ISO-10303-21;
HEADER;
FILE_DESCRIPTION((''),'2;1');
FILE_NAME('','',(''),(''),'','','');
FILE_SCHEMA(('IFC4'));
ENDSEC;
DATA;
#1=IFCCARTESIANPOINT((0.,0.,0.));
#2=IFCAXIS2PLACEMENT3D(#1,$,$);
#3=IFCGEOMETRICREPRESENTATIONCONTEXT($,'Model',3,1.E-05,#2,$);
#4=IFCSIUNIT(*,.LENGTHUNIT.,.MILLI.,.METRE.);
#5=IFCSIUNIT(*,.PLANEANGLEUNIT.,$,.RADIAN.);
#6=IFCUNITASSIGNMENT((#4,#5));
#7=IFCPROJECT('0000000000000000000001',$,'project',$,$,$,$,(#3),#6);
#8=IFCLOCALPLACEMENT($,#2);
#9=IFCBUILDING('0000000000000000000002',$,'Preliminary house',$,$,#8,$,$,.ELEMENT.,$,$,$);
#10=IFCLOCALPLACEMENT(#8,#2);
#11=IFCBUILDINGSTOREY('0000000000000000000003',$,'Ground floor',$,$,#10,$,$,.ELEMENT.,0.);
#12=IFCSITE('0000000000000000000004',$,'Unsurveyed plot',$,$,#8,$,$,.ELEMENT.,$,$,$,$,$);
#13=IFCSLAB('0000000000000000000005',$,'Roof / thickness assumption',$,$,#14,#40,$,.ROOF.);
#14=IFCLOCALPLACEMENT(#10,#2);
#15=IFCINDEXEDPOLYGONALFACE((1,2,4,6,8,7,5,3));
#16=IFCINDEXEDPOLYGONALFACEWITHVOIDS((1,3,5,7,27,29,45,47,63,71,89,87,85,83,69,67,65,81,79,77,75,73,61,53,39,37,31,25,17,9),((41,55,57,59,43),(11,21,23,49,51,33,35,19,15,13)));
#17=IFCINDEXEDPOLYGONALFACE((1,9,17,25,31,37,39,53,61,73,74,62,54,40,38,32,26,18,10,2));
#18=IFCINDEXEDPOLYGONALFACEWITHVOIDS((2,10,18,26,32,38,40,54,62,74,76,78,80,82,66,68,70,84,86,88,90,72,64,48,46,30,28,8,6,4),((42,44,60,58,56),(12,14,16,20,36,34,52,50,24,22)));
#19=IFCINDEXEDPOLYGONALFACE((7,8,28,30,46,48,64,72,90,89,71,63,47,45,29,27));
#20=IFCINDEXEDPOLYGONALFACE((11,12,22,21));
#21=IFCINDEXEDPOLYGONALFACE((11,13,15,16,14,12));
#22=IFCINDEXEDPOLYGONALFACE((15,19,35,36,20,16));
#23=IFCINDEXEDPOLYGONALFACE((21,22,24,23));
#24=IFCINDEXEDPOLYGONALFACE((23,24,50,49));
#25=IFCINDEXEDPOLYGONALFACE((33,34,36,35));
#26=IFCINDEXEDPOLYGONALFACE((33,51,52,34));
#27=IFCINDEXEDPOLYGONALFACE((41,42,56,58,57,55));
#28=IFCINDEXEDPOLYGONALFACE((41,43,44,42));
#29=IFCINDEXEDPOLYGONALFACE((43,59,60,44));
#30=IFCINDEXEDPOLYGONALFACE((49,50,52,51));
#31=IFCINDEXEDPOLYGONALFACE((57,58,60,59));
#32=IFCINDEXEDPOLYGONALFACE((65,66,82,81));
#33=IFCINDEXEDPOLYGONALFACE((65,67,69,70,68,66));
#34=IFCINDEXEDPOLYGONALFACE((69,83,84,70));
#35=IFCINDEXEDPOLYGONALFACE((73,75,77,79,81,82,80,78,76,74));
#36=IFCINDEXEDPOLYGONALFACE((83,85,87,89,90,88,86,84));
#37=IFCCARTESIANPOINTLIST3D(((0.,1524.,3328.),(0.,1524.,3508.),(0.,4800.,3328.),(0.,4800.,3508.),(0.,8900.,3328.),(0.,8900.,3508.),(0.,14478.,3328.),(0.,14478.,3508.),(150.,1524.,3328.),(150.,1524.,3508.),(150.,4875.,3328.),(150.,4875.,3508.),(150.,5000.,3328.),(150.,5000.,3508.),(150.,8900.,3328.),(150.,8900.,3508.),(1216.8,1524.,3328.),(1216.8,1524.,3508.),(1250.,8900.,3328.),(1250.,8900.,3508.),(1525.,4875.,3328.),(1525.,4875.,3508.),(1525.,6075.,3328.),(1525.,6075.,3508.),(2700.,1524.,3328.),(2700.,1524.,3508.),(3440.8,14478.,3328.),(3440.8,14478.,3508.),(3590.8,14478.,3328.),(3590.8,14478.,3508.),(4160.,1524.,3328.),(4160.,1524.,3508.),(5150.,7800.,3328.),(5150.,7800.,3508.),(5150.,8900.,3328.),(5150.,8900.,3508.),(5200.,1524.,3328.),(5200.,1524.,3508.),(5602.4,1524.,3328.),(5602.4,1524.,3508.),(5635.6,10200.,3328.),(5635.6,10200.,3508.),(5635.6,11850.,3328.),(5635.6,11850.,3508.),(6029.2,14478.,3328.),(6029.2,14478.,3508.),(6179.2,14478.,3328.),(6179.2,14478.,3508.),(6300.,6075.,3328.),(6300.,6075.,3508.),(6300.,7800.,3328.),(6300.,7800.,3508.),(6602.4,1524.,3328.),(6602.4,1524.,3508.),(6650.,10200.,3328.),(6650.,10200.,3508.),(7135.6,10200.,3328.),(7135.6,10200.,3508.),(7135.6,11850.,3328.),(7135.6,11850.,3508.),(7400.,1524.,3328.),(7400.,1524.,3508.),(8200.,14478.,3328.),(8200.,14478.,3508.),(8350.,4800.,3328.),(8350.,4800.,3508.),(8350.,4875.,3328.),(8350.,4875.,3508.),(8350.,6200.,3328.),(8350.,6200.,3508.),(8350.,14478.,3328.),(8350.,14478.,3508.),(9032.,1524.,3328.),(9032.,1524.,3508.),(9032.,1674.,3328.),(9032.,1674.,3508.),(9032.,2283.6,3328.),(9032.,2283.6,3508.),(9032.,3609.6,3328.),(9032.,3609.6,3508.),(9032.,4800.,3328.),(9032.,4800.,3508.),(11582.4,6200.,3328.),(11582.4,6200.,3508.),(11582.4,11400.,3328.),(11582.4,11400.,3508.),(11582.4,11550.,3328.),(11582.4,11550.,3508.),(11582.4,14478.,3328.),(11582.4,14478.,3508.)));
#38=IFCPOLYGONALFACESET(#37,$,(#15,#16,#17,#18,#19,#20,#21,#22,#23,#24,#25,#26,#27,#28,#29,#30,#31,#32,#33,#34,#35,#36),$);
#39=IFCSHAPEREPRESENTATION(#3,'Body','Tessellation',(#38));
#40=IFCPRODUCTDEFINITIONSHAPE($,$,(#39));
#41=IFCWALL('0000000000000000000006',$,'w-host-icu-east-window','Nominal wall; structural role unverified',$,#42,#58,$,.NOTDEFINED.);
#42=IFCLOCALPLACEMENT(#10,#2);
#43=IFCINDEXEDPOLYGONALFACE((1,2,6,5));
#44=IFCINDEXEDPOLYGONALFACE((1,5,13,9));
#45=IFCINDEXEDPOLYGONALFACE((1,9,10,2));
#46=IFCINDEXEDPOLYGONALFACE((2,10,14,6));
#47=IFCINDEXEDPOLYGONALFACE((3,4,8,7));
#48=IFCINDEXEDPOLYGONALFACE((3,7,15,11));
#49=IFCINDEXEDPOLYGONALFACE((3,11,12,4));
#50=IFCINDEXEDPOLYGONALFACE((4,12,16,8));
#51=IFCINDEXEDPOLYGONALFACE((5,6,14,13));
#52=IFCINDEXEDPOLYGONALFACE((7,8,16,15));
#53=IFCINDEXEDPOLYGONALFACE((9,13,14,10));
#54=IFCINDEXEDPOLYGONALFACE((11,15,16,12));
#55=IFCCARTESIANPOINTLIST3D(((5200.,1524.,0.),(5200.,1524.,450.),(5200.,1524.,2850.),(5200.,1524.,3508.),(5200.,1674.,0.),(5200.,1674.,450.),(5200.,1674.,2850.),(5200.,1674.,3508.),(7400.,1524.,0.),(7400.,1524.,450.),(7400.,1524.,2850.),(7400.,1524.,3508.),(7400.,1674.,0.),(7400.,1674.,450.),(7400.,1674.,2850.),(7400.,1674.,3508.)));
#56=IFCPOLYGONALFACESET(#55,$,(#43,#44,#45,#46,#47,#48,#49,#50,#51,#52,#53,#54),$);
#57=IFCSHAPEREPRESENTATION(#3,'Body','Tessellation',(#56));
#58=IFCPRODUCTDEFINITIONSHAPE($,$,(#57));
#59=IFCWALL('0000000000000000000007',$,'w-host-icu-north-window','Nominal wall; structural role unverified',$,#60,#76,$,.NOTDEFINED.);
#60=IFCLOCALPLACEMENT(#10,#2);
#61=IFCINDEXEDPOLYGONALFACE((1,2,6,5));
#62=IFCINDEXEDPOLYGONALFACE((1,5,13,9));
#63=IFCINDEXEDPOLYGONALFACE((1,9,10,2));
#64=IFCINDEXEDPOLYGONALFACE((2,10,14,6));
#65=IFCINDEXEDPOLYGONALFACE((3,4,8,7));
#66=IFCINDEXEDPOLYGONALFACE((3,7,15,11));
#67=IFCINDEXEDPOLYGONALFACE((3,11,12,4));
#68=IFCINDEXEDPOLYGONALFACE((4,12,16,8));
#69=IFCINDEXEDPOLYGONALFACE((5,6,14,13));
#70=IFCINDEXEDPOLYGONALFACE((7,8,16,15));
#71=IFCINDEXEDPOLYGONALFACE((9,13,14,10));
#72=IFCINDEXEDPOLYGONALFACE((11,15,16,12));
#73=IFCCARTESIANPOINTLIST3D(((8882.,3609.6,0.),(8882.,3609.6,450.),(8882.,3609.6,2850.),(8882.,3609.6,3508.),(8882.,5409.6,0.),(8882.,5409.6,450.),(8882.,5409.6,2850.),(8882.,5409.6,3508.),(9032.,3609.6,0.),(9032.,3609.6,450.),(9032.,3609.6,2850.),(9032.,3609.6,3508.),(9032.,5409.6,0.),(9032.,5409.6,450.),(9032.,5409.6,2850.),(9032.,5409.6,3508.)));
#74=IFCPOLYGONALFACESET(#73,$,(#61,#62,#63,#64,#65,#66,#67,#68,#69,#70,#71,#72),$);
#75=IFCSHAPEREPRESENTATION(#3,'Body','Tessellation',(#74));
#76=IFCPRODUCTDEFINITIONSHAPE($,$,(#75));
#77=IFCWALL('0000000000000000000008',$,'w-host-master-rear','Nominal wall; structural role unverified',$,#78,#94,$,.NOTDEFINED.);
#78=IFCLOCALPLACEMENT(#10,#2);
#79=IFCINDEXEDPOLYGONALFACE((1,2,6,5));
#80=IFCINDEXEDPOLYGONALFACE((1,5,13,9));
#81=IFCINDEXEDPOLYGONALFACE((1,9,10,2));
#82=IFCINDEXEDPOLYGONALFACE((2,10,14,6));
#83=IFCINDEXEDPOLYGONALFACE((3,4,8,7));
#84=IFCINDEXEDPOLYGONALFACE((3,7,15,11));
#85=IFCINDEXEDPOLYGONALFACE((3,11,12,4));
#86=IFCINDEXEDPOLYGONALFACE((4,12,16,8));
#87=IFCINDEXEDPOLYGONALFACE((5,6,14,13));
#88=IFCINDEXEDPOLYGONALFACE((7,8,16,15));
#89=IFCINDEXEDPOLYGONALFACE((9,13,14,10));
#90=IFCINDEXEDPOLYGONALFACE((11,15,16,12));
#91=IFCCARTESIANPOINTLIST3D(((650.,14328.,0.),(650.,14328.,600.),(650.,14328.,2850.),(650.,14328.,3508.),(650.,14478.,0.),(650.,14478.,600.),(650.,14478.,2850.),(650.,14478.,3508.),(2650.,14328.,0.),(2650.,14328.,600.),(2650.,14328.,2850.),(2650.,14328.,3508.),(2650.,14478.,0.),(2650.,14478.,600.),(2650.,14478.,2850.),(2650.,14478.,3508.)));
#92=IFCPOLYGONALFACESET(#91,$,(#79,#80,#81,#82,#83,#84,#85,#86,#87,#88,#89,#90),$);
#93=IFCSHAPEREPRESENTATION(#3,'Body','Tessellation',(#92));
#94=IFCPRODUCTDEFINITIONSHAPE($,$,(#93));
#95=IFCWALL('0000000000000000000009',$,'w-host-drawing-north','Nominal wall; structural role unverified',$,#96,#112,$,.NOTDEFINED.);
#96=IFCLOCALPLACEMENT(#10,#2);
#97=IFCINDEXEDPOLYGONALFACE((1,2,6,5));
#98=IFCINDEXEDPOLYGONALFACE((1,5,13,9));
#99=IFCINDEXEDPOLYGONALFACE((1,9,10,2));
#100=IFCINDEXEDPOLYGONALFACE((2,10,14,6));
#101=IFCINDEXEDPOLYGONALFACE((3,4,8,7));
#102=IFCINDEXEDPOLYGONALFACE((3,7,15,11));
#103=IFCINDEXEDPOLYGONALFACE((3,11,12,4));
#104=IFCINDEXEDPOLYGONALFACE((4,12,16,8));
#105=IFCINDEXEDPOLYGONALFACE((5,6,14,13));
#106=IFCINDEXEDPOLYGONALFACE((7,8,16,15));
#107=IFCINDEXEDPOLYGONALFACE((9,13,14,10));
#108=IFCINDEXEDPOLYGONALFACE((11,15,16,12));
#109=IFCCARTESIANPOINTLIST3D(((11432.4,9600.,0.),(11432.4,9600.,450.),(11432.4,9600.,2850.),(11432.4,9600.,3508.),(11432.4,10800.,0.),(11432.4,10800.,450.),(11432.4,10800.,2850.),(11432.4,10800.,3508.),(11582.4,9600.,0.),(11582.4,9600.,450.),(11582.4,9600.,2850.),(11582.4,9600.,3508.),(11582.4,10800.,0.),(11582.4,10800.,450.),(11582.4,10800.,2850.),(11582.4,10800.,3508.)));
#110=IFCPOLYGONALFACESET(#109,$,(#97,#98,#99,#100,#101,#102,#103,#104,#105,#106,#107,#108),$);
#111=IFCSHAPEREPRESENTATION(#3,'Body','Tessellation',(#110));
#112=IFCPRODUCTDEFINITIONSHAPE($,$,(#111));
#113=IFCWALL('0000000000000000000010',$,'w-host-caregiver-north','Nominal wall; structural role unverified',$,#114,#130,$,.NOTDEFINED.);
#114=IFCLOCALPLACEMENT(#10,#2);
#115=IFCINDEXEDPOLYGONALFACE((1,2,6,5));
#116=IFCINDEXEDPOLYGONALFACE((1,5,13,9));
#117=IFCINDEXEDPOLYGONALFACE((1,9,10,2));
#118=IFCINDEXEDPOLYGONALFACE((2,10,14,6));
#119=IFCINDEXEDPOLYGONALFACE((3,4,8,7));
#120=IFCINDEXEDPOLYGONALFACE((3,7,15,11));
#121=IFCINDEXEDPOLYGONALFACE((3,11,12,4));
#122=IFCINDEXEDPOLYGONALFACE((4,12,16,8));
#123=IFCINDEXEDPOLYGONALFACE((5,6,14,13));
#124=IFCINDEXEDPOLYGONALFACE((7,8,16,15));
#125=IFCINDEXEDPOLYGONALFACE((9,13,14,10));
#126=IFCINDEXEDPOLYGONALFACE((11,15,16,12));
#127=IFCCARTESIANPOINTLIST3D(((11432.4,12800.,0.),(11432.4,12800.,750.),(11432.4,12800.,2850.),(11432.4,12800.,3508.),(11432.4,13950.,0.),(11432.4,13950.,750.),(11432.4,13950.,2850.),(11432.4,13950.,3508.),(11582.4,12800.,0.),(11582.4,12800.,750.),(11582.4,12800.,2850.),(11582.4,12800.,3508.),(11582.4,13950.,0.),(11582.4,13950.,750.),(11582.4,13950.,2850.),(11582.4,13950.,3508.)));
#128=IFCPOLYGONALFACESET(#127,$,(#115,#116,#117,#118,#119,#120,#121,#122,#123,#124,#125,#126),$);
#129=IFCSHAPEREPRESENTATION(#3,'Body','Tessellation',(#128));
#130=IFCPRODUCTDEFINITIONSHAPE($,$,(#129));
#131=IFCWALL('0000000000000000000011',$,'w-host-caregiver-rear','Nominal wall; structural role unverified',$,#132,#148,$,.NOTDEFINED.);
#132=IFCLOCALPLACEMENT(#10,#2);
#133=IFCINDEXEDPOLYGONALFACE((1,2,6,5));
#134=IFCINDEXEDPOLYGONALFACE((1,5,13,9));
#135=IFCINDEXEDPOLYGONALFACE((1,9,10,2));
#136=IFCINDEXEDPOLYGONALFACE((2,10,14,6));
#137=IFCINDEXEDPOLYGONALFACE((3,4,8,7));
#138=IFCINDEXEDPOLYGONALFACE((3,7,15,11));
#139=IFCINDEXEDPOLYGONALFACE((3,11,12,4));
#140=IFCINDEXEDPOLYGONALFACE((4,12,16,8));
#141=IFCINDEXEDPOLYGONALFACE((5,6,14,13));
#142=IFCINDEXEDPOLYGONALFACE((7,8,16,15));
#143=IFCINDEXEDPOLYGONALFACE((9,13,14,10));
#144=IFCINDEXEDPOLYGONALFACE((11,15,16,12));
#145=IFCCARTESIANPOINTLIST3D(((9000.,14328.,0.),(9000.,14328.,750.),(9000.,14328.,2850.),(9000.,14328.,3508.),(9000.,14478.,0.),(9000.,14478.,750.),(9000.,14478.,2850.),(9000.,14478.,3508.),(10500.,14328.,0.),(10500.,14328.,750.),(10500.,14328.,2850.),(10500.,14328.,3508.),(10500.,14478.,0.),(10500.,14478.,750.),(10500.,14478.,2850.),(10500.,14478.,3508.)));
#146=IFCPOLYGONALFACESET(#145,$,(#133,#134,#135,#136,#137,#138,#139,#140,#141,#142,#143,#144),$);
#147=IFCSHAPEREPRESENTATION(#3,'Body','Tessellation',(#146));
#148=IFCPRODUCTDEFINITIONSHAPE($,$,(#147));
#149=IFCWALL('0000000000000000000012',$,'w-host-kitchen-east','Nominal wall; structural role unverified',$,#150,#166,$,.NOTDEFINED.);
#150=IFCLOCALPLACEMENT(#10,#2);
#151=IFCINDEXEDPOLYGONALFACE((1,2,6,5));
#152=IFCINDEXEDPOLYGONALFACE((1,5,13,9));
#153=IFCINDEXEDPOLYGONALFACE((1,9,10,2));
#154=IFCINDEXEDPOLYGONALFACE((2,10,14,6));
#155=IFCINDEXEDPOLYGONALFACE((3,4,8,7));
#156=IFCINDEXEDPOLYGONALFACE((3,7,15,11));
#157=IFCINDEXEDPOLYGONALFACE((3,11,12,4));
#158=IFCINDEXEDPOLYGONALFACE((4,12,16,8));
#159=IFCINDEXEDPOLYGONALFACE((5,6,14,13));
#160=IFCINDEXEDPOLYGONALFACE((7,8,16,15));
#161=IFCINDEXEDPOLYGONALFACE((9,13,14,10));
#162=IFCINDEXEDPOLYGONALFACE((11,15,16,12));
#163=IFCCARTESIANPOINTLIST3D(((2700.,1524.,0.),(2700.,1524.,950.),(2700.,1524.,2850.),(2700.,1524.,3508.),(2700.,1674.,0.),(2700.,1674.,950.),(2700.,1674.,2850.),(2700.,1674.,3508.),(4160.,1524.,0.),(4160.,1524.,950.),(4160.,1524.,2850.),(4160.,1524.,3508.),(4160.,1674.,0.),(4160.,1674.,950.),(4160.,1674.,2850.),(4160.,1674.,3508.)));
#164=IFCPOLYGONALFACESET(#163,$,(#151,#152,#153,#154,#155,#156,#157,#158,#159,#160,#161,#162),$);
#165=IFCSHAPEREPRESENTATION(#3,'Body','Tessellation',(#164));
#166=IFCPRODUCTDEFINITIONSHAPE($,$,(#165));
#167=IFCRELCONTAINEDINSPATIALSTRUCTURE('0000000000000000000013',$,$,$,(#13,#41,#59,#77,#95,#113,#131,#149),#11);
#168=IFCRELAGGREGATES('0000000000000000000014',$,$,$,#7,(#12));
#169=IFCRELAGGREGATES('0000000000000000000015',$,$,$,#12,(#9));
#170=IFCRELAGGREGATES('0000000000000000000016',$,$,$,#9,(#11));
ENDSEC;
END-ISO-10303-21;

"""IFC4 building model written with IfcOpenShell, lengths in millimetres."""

from ifc_helpers import new_model, si_unit, frame, origin, place, context, project, spatial, polyline, outline, extrude, element, save


model = new_model("IFC4")

# Units and contexts
model_context = context("Model", 3, precision=1e-05, world=origin())
ifc_project = project(units=[si_unit("LENGTHUNIT", "METRE", prefix="MILLI"), si_unit("PLANEANGLEUNIT", "RADIAN")], contexts=[model_context])

# Site, building, storey
placement_1 = place(None, origin())
site = spatial("IfcSite", under=ifc_project, at=placement_1, Name="Unsurveyed plot", CompositionType="ELEMENT")
building = spatial("IfcBuilding", under=site, at=placement_1, Name="Preliminary house", CompositionType="ELEMENT")
placement_2 = place(placement_1, origin())
storey = spatial("IfcBuildingStorey", under=building, at=placement_2, Name="Ground floor", CompositionType="ELEMENT", Elevation=0.0)

# Slab
element("IfcSlab", 1, at=placement_2, inside=storey, Name="Roof / thickness assumption", PredefinedType="ROOF", context=model_context, shape_type="SweptSolid", body=[
    extrude(outline(polyline([(5602.4, 1524.0), (5200.0, 1524.0), (4160.0, 1524.0), (2700.0, 1524.0), (1216.8, 1524.0), (150.0, 1524.0), (0.0, 1524.0), (0.0, 4800.0), (0.0, 8900.0), (0.0, 14478.0), (3440.8, 14478.0), (3590.8, 14478.0), (6029.2, 14478.0), (6179.2, 14478.0), (8200.0, 14478.0), (8350.0, 14478.0), (11582.4, 14478.0), (11582.4, 11550.0), (11582.4, 11400.0), (11582.4, 6200.0), (8350.0, 6200.0), (8350.0, 4875.0), (8350.0, 4800.0), (9032.0, 4800.0), (9032.0, 3609.6), (9032.0, 2283.6), (9032.0, 1674.0), (9032.0, 1524.0), (7400.0, 1524.0), (6602.4, 1524.0), (5602.4, 1524.0)]), holes=[polyline([(5150.0, 8900.0), (1250.0, 8900.0), (150.0, 8900.0), (150.0, 5000.0), (150.0, 4875.0), (1525.0, 4875.0), (1525.0, 6075.0), (6300.0, 6075.0), (6300.0, 7800.0), (5150.0, 7800.0), (5150.0, 8900.0)]), polyline([(7135.6, 10200.0), (7135.6, 11850.0), (5635.6, 11850.0), (5635.6, 10200.0), (6650.0, 10200.0), (7135.6, 10200.0)])]), frame((0.0, 0.0, 3328.0)), (0.0, 0.0, 1.0), 180.0),
])

# Walls, openings
wall_1 = element("IfcWall", 2, at=placement_2, inside=storey, Name="w-host-icu-east-window", Description="Nominal wall; structural role unverified", PredefinedType="NOTDEFINED", context=model_context, shape_type="SweptSolid", body=[
    extrude(outline(polyline([(5200.0, 1524.0), (7400.0, 1524.0), (7400.0, 1674.0), (5200.0, 1674.0), (5200.0, 1524.0)])), origin(), (0.0, 0.0, 1.0), 3508.0),
])
element("IfcOpeningElement", 3, at=placement_2, cuts=wall_1, PredefinedType="OPENING", context=model_context, shape_type="SweptSolid", body=[
    extrude(outline(polyline([(5200.0, 1149.0), (7400.0, 1149.0), (7400.0, 2049.0), (5200.0, 2049.0), (5200.0, 1149.0)])), frame((0.0, 0.0, 450.0)), (0.0, 0.0, 1.0), 2400.0),
])
wall_2 = element("IfcWall", 4, at=placement_2, inside=storey, Name="w-host-icu-north-window", Description="Nominal wall; structural role unverified", PredefinedType="NOTDEFINED", context=model_context, shape_type="SweptSolid", body=[
    extrude(outline(polyline([(9032.0, 3609.6), (9032.0, 5409.6), (8882.0, 5409.6), (8882.0, 3609.6), (9032.0, 3609.6)])), origin(), (0.0, 0.0, 1.0), 3508.0),
])
element("IfcOpeningElement", 5, at=placement_2, cuts=wall_2, PredefinedType="OPENING", context=model_context, shape_type="SweptSolid", body=[
    extrude(outline(polyline([(9407.0, 3609.6), (9407.0, 5409.6), (8507.0, 5409.6), (8507.0, 3609.6), (9407.0, 3609.6)])), frame((0.0, 0.0, 450.0)), (0.0, 0.0, 1.0), 2400.0),
])
wall_3 = element("IfcWall", 6, at=placement_2, inside=storey, Name="w-host-master-rear", Description="Nominal wall; structural role unverified", PredefinedType="NOTDEFINED", context=model_context, shape_type="SweptSolid", body=[
    extrude(outline(polyline([(650.0, 14328.0), (2650.0, 14328.0), (2650.0, 14478.0), (650.0, 14478.0), (650.0, 14328.0)])), origin(), (0.0, 0.0, 1.0), 3508.0),
])
element("IfcOpeningElement", 7, at=placement_2, cuts=wall_3, PredefinedType="OPENING", context=model_context, shape_type="SweptSolid", body=[
    extrude(outline(polyline([(650.0, 13953.0), (2650.0, 13953.0), (2650.0, 14853.0), (650.0, 14853.0), (650.0, 13953.0)])), frame((0.0, 0.0, 600.0)), (0.0, 0.0, 1.0), 2250.0),
])
wall_4 = element("IfcWall", 8, at=placement_2, inside=storey, Name="w-host-drawing-north", Description="Nominal wall; structural role unverified", PredefinedType="NOTDEFINED", context=model_context, shape_type="SweptSolid", body=[
    extrude(outline(polyline([(11582.4, 9600.0), (11582.4, 10800.0), (11432.4, 10800.0), (11432.4, 9600.0), (11582.4, 9600.0)])), origin(), (0.0, 0.0, 1.0), 3508.0),
])
element("IfcOpeningElement", 9, at=placement_2, cuts=wall_4, PredefinedType="OPENING", context=model_context, shape_type="SweptSolid", body=[
    extrude(outline(polyline([(11957.4, 9600.0), (11957.4, 10800.0), (11057.4, 10800.0), (11057.4, 9600.0), (11957.4, 9600.0)])), frame((0.0, 0.0, 450.0)), (0.0, 0.0, 1.0), 2400.0),
])
wall_5 = element("IfcWall", 10, at=placement_2, inside=storey, Name="w-host-caregiver-north", Description="Nominal wall; structural role unverified", PredefinedType="NOTDEFINED", context=model_context, shape_type="SweptSolid", body=[
    extrude(outline(polyline([(11582.4, 12800.0), (11582.4, 13950.0), (11432.4, 13950.0), (11432.4, 12800.0), (11582.4, 12800.0)])), origin(), (0.0, 0.0, 1.0), 3508.0),
])
element("IfcOpeningElement", 11, at=placement_2, cuts=wall_5, PredefinedType="OPENING", context=model_context, shape_type="SweptSolid", body=[
    extrude(outline(polyline([(11957.4, 12800.0), (11957.4, 13950.0), (11057.4, 13950.0), (11057.4, 12800.0), (11957.4, 12800.0)])), frame((0.0, 0.0, 750.0)), (0.0, 0.0, 1.0), 2100.0),
])
wall_6 = element("IfcWall", 12, at=placement_2, inside=storey, Name="w-host-caregiver-rear", Description="Nominal wall; structural role unverified", PredefinedType="NOTDEFINED", context=model_context, shape_type="SweptSolid", body=[
    extrude(outline(polyline([(9000.0, 14328.0), (10500.0, 14328.0), (10500.0, 14478.0), (9000.0, 14478.0), (9000.0, 14328.0)])), origin(), (0.0, 0.0, 1.0), 3508.0),
])
element("IfcOpeningElement", 13, at=placement_2, cuts=wall_6, PredefinedType="OPENING", context=model_context, shape_type="SweptSolid", body=[
    extrude(outline(polyline([(9000.0, 13953.0), (10500.0, 13953.0), (10500.0, 14853.0), (9000.0, 14853.0), (9000.0, 13953.0)])), frame((0.0, 0.0, 750.0)), (0.0, 0.0, 1.0), 2100.0),
])
wall_7 = element("IfcWall", 14, at=placement_2, inside=storey, Name="w-host-kitchen-east", Description="Nominal wall; structural role unverified", PredefinedType="NOTDEFINED", context=model_context, shape_type="SweptSolid", body=[
    extrude(outline(polyline([(2700.0, 1524.0), (4160.0, 1524.0), (4160.0, 1674.0), (2700.0, 1674.0), (2700.0, 1524.0)])), origin(), (0.0, 0.0, 1.0), 3508.0),
])
element("IfcOpeningElement", 15, at=placement_2, cuts=wall_7, PredefinedType="OPENING", context=model_context, shape_type="SweptSolid", body=[
    extrude(outline(polyline([(2700.0, 1149.0), (4160.0, 1149.0), (4160.0, 2049.0), (2700.0, 2049.0), (2700.0, 1149.0)])), frame((0.0, 0.0, 950.0)), (0.0, 0.0, 1.0), 1900.0),
])

save(model, "model.ifc")
